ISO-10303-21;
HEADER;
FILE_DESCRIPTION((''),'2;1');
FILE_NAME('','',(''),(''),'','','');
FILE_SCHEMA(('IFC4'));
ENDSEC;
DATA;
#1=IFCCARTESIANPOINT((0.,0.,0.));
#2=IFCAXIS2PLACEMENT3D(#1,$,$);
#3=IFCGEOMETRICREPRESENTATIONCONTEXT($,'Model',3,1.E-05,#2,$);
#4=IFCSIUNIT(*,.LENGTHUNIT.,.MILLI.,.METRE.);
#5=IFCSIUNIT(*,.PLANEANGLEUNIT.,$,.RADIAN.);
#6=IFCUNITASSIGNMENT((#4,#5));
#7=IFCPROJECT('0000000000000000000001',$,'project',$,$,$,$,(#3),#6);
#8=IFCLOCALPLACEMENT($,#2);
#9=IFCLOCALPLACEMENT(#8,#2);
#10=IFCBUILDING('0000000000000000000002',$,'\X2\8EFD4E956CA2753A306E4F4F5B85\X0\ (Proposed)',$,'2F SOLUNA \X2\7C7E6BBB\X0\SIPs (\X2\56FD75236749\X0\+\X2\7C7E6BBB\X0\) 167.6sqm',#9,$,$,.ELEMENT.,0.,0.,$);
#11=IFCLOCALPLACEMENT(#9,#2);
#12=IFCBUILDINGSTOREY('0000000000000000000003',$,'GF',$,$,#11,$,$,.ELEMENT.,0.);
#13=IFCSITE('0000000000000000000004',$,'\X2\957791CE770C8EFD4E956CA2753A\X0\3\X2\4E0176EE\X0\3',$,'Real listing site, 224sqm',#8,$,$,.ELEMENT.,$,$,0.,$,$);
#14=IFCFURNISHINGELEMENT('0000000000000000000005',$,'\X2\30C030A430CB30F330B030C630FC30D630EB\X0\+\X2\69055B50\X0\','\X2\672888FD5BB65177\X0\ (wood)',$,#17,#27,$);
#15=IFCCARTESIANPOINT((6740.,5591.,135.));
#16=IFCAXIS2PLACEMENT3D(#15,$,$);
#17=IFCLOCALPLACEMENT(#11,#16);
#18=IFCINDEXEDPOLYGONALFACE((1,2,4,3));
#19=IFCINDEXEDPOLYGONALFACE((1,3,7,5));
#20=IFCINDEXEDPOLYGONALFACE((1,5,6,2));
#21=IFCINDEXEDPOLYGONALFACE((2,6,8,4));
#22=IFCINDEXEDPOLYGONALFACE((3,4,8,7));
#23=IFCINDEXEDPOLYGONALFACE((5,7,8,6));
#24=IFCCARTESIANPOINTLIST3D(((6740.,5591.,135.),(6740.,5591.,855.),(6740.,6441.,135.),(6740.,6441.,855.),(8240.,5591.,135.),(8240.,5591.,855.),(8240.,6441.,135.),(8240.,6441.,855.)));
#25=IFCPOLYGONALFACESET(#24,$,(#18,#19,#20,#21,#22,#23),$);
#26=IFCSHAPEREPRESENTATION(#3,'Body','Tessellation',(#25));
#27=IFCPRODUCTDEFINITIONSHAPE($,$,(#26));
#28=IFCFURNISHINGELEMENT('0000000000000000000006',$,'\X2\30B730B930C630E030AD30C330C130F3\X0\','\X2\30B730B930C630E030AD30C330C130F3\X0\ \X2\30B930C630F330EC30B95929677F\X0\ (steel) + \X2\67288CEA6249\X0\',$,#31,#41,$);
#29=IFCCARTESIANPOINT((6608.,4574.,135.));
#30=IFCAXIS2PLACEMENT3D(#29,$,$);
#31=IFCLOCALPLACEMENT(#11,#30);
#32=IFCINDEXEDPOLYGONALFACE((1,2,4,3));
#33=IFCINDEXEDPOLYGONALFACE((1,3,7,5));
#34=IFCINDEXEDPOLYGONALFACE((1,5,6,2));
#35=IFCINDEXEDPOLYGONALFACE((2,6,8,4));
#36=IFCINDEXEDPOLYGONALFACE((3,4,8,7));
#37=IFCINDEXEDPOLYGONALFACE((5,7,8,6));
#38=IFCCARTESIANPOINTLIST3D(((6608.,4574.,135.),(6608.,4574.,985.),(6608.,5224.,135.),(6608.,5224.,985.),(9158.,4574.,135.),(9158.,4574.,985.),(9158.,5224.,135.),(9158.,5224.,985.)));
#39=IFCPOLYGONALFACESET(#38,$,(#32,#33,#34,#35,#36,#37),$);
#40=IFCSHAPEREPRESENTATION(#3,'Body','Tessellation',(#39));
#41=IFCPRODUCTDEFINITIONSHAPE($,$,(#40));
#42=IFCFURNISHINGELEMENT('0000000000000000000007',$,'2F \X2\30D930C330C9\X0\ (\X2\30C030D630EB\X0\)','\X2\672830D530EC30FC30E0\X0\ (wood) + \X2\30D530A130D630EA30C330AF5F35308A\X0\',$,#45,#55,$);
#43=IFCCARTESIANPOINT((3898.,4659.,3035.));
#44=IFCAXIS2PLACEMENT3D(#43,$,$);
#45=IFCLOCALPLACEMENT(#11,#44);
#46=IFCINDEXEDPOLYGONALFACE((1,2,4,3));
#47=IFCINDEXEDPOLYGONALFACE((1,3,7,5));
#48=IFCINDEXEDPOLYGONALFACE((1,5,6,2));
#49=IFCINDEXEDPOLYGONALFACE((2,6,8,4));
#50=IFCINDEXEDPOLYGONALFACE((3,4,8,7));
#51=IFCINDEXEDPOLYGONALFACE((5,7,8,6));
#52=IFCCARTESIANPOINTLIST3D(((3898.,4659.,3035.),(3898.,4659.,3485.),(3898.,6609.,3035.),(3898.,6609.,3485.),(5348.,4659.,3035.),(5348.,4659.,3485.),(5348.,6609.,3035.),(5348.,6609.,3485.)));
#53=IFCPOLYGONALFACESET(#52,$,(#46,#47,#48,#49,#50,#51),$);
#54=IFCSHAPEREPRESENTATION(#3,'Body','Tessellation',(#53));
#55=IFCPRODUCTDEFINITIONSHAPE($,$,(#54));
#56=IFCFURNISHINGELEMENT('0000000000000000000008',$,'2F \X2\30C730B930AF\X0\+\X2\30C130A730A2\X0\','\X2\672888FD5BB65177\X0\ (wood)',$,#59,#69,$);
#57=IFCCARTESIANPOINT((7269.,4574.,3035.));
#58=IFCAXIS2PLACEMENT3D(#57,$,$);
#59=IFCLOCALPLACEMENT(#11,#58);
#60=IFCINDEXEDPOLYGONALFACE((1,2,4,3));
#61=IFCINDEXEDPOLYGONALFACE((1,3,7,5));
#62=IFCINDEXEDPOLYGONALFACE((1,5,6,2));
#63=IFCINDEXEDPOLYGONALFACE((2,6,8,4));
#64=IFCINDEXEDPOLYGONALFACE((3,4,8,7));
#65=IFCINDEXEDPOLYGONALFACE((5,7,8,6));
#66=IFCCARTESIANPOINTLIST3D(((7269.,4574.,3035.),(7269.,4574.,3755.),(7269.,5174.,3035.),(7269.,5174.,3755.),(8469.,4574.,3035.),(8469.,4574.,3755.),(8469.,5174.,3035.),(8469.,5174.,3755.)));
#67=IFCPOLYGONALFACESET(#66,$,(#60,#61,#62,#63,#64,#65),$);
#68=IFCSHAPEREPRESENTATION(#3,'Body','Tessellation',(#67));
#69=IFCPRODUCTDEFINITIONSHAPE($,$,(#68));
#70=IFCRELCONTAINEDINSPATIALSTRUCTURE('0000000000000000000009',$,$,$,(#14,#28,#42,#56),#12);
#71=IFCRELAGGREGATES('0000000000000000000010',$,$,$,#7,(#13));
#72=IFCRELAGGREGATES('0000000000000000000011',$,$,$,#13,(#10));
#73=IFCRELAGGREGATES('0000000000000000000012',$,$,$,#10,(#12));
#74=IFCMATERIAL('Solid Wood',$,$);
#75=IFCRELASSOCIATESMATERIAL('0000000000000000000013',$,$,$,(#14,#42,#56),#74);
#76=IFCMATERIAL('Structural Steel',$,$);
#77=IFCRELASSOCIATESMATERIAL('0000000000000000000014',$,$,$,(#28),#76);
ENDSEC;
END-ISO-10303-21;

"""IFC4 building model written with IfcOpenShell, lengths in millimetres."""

from ifc_helpers import new_model, si_unit, frame, frame_2d, origin, place, context, project, spatial, rectangle, extrude, material, element, save


model = new_model("IFC4")

# Units and contexts
model_context = context("Model", 3, precision=1e-05, world=origin())
ifc_project = project(units=[si_unit("LENGTHUNIT", "METRE", prefix="MILLI"), si_unit("PLANEANGLEUNIT", "RADIAN")], contexts=[model_context])

# Site, building, storey
site_placement = place(None, origin())
site = spatial("IfcSite", under=ifc_project, at=site_placement, Name="長野県軽井沢町3丁目3", ObjectType="Real listing site, 224sqm", CompositionType="ELEMENT", RefElevation=0.0)
building_placement = place(site_placement, origin())
building = spatial("IfcBuilding", under=site, at=building_placement, Name="軽井沢町の住宅 (Proposed)", ObjectType="2F SOLUNA 籾殻SIPs (国産杉+籾殻) 167.6sqm", CompositionType="ELEMENT", ElevationOfRefHeight=0.0, ElevationOfTerrain=0.0)
storey_placement = place(building_placement, origin())
storey = spatial("IfcBuildingStorey", under=building, at=storey_placement, Name="GF", CompositionType="ELEMENT", Elevation=0.0)

# Shared definitions
ifc_material_1 = material(Name="Solid Wood")

# Shared definitions
ifc_material_2 = material(Name="Structural Steel")

# Furnishing elements
furnishing_1_placement = place(storey_placement, frame((6740.0, 5591.0, 135.0)))
element("IfcFurnishingElement", 1, at=furnishing_1_placement, inside=storey, material=ifc_material_1, Name="ダイニングテーブル+椅子", Description="木製家具 (wood)", context=model_context, shape_type="SweptSolid", body=[
    extrude(rectangle(XDim=1500.0, YDim=850.0, at=frame_2d((750.0, 425.0))), frame((6740.0, 5591.0, 135.0)), (0.0, 0.0, 1.0), 720.0),
])
furnishing_2_placement = place(storey_placement, frame((6608.0, 4574.0, 135.0)))
element("IfcFurnishingElement", 2, at=furnishing_2_placement, inside=storey, material=ifc_material_2, Name="システムキッチン", Description="システムキッチン ステンレス天板 (steel) + 木質扉", context=model_context, shape_type="SweptSolid", body=[
    extrude(rectangle(XDim=2550.0, YDim=650.0, at=frame_2d((1275.0, 325.0))), frame((6608.0, 4574.0, 135.0)), (0.0, 0.0, 1.0), 850.0),
])
furnishing_3_placement = place(storey_placement, frame((3898.0, 4659.0, 3035.0)))
element("IfcFurnishingElement", 3, at=furnishing_3_placement, inside=storey, material=ifc_material_1, Name="2F ベッド (ダブル)", Description="木フレーム (wood) + ファブリック張り", context=model_context, shape_type="SweptSolid", body=[
    extrude(rectangle(XDim=1450.0, YDim=1950.0, at=frame_2d((725.0, 975.0))), frame((3898.0, 4659.0, 3035.0)), (0.0, 0.0, 1.0), 450.0),
])
furnishing_4_placement = place(storey_placement, frame((7269.0, 4574.0, 3035.0)))
element("IfcFurnishingElement", 4, at=furnishing_4_placement, inside=storey, material=ifc_material_1, Name="2F デスク+チェア", Description="木製家具 (wood)", context=model_context, shape_type="SweptSolid", body=[
    extrude(rectangle(XDim=1200.0, YDim=600.0, at=frame_2d((600.0, 300.0))), frame((7269.0, 4574.0, 3035.0)), (0.0, 0.0, 1.0), 720.0),
])

save(model, "model.ifc")
